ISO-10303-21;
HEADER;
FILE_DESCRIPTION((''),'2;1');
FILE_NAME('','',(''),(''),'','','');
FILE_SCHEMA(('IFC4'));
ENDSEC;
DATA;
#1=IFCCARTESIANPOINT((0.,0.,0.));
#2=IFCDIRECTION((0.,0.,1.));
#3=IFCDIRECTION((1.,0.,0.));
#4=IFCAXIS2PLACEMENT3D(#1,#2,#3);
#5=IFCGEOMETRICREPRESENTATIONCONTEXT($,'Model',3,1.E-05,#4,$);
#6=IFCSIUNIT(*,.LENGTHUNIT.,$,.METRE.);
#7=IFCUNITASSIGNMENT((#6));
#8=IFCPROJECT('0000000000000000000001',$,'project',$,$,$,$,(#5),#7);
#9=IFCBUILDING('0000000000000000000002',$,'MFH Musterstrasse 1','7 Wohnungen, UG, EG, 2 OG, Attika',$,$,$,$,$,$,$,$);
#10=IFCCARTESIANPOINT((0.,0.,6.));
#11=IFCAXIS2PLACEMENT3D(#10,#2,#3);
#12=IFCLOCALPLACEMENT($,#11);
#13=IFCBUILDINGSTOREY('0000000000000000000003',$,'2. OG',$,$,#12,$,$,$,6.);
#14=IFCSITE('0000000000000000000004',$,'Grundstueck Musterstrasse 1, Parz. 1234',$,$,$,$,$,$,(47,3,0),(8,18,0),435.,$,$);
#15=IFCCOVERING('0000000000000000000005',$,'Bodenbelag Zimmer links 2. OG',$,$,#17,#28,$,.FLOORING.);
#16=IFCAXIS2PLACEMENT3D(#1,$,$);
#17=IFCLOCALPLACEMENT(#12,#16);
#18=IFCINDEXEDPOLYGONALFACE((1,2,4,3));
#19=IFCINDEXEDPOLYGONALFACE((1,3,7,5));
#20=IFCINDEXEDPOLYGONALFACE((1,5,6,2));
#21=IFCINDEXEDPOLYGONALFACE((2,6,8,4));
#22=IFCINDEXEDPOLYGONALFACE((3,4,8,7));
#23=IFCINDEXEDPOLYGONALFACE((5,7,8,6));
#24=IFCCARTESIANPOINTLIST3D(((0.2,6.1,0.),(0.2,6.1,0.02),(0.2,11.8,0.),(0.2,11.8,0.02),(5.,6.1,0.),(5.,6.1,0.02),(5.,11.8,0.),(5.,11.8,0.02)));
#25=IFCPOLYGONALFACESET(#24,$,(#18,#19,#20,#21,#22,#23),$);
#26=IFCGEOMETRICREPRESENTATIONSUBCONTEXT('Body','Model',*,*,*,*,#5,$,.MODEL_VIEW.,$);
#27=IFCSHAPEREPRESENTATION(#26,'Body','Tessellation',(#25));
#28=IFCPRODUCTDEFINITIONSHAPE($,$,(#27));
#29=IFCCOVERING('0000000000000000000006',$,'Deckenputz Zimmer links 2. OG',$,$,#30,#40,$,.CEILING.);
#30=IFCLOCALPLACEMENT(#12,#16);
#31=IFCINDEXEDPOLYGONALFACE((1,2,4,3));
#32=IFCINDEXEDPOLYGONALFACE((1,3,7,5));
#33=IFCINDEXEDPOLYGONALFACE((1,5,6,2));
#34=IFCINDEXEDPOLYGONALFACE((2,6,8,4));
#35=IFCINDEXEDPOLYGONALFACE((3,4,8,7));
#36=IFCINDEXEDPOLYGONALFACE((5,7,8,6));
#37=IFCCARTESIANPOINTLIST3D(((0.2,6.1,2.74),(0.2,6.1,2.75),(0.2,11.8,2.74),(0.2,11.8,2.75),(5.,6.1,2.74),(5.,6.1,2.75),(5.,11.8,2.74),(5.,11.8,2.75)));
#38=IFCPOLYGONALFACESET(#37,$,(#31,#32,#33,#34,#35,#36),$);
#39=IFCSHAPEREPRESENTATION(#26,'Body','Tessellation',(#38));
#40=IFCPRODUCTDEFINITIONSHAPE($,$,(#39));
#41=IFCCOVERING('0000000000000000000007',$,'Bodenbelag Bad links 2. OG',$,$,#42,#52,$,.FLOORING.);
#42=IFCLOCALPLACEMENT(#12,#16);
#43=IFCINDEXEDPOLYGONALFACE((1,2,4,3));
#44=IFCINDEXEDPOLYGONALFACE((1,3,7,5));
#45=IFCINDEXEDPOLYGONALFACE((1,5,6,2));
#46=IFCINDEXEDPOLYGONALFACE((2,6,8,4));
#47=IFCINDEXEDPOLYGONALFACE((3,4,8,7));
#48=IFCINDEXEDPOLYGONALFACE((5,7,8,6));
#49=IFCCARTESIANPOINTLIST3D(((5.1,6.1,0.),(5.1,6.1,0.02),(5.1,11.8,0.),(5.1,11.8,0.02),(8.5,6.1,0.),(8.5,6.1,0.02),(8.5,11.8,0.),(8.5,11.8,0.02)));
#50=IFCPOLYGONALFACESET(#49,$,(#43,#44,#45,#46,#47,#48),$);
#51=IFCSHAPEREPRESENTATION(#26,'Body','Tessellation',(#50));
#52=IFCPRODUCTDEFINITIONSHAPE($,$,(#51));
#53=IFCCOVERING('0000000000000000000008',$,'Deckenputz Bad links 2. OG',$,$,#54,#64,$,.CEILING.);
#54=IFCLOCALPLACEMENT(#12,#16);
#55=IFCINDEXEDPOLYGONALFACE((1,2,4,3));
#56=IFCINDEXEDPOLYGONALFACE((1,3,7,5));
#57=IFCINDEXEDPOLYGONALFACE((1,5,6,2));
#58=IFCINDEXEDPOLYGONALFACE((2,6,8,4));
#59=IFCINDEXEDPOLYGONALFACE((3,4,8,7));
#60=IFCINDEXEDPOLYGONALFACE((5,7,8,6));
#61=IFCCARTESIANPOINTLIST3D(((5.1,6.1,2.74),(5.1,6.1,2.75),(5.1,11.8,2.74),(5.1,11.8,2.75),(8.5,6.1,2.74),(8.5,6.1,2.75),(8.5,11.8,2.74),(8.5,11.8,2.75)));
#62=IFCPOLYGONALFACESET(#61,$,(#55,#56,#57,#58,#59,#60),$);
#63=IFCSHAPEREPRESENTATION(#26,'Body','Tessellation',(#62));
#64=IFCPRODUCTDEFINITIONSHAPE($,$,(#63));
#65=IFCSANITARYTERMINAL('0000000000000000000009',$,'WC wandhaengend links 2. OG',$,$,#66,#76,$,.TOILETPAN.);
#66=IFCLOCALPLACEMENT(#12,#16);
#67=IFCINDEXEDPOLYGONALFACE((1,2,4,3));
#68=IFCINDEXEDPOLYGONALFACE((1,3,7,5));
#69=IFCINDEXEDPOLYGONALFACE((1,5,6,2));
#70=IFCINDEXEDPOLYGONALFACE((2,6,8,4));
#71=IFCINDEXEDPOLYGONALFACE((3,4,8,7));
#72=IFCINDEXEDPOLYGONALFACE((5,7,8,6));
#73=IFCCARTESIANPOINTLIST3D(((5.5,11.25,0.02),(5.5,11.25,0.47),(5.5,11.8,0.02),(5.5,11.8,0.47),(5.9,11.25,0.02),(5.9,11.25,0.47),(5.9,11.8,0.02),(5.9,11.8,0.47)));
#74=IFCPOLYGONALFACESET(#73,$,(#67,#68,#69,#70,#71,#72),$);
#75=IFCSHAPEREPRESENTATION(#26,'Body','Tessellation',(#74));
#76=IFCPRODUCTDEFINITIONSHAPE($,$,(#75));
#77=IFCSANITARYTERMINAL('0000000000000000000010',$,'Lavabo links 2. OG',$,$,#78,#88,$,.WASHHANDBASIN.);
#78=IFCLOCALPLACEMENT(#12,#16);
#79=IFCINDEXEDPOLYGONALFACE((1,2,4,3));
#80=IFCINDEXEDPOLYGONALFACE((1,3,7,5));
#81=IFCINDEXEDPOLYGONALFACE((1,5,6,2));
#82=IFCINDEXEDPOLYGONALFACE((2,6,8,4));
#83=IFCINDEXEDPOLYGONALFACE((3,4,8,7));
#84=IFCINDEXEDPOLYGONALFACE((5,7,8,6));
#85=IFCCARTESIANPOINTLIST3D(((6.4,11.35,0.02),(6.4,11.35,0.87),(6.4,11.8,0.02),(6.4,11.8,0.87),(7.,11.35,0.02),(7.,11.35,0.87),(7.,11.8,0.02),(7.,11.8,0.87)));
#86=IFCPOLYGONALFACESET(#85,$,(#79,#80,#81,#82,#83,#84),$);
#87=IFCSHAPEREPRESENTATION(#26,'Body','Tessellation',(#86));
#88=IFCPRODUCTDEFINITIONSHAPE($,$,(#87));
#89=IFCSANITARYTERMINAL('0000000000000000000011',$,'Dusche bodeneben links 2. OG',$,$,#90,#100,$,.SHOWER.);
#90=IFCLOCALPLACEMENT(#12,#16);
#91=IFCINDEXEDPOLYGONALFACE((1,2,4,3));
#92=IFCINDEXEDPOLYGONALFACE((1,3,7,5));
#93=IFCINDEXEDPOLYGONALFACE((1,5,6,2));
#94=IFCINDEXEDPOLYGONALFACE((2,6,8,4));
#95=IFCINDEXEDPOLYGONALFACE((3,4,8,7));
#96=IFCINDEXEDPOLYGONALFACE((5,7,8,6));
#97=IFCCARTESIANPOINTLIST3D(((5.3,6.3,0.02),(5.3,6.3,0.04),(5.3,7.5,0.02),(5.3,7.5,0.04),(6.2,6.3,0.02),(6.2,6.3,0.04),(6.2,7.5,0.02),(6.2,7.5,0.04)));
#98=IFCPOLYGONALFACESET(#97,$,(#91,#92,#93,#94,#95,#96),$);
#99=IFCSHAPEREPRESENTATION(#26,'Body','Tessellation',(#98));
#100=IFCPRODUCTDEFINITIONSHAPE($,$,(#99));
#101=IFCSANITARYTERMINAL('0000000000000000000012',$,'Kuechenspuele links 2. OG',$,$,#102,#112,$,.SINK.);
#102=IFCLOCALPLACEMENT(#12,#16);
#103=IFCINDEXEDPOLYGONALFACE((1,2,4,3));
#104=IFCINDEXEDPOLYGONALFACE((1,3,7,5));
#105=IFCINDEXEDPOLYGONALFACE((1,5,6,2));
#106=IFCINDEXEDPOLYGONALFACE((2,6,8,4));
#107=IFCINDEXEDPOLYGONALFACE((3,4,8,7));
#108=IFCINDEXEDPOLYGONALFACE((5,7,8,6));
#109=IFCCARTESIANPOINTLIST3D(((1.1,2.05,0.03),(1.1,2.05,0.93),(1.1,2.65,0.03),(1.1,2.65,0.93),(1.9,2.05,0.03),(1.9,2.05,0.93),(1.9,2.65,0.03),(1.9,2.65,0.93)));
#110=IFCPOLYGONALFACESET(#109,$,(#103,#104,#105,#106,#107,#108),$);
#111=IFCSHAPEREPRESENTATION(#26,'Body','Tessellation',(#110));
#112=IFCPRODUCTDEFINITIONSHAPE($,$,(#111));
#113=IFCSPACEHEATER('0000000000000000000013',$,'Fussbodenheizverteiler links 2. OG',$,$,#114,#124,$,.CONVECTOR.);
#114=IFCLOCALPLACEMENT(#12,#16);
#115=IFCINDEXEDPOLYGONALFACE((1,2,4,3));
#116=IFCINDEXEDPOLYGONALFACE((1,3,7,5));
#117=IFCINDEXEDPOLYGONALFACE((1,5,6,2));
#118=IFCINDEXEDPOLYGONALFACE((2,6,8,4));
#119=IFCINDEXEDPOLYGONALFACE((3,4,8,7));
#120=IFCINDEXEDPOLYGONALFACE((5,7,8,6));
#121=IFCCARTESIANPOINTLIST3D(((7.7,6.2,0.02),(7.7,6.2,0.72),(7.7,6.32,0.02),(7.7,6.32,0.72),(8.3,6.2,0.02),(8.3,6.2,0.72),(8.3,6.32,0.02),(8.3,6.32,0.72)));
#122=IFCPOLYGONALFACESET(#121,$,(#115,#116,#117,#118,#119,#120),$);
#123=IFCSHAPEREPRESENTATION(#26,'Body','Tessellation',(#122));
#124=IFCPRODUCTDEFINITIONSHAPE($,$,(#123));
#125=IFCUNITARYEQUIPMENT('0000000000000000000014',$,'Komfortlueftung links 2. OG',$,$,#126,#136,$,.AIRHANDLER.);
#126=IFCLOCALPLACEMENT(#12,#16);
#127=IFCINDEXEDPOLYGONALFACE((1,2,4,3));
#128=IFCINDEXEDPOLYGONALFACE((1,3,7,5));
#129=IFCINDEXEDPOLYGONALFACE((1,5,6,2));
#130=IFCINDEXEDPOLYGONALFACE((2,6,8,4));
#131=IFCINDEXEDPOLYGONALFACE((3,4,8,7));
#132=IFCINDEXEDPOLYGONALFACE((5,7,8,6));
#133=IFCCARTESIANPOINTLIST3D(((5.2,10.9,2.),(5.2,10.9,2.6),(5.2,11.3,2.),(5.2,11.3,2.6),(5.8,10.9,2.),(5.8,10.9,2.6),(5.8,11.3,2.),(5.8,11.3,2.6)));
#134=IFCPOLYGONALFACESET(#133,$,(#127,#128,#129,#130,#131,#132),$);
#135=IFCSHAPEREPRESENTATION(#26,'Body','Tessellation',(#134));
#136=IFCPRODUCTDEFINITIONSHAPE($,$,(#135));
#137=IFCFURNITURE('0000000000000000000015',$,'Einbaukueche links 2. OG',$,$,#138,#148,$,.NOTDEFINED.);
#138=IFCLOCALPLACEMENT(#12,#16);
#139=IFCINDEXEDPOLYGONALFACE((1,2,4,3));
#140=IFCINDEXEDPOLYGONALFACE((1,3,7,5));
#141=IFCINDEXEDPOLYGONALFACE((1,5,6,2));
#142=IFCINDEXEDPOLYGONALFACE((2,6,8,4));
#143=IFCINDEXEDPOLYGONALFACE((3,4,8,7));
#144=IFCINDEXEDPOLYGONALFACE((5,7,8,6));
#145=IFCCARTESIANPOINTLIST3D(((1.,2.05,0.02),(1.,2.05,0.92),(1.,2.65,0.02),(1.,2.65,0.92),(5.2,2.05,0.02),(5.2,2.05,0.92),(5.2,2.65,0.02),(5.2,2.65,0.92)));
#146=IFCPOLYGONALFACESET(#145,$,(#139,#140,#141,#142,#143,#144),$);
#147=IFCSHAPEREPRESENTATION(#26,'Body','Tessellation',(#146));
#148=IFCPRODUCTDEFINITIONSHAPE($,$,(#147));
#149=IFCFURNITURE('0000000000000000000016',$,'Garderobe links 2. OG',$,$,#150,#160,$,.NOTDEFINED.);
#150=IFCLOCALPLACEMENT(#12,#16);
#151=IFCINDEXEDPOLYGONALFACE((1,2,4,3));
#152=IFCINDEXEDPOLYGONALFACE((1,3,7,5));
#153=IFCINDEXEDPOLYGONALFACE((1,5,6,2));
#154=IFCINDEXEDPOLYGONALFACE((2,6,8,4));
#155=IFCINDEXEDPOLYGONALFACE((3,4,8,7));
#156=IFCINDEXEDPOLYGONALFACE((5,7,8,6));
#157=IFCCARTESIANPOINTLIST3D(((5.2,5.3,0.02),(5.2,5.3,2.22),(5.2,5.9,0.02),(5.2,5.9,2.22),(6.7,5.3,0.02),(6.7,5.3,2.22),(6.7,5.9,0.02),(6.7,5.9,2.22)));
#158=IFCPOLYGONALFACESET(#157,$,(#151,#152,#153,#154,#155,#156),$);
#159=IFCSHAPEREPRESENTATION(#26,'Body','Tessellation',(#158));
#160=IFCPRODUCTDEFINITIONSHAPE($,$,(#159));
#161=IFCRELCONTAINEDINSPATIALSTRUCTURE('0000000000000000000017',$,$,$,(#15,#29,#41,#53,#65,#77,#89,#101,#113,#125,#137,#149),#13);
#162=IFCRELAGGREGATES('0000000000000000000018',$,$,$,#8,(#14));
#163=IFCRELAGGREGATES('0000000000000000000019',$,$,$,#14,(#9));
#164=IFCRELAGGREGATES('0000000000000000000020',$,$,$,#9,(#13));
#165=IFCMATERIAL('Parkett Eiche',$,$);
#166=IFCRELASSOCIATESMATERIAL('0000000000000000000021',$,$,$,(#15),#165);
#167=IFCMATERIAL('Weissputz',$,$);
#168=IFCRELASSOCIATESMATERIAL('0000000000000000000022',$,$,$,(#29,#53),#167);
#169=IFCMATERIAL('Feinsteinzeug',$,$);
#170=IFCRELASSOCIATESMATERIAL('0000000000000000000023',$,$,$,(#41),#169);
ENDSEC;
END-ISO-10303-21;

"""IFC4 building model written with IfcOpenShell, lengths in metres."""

from ifc_helpers import new_model, si_unit, frame, frame_2d, origin_with_axes, place, context, subcontext, project, spatial, rectangle, extrude, material, element, save


model = new_model("IFC4")

# Units and contexts
model_context = context("Model", 3, precision=1e-05, world=origin_with_axes())
body_context = subcontext(model_context, "Body", "Model", "MODEL_VIEW")
ifc_project = project(units=[si_unit("LENGTHUNIT", "METRE")], contexts=[model_context])

# Site, building, storey
site = spatial("IfcSite", under=ifc_project, Name="Grundstueck Musterstrasse 1, Parz. 1234", RefLatitude=(47, 3, 0), RefLongitude=(8, 18, 0), RefElevation=435.0)
building = spatial("IfcBuilding", under=site, Name="MFH Musterstrasse 1", Description="7 Wohnungen, UG, EG, 2 OG, Attika")
storey_placement = place(None, frame((0.0, 0.0, 6.0), z_axis=(0.0, 0.0, 1.0), x_axis=(1.0, 0.0, 0.0)))
storey = spatial("IfcBuildingStorey", under=building, at=storey_placement, Name="2. OG", Elevation=6.0)

# Coverings
ifc_material_1 = material(Name="Parkett Eiche")
covering_1_placement = place(storey_placement, frame((0.2, 6.1, 0.0), z_axis=(0.0, 0.0, 1.0), x_axis=(1.0, 0.0, 0.0)))
element("IfcCovering", 1, at=covering_1_placement, inside=storey, material=ifc_material_1, Name="Bodenbelag Zimmer links 2. OG", PredefinedType="FLOORING", context=body_context, shape_type="SweptSolid", body=[
    extrude(rectangle(XDim=4.8, YDim=5.7, at=frame_2d((2.4, 2.85))), origin_with_axes(), (0.0, 0.0, 1.0), 0.02),
])
ifc_material_2 = material(Name="Weissputz")
covering_2_placement = place(storey_placement, frame((0.2, 6.1, 2.74), z_axis=(0.0, 0.0, 1.0), x_axis=(1.0, 0.0, 0.0)))
element("IfcCovering", 2, at=covering_2_placement, inside=storey, material=ifc_material_2, Name="Deckenputz Zimmer links 2. OG", PredefinedType="CEILING", context=body_context, shape_type="SweptSolid", body=[
    extrude(rectangle(XDim=4.8, YDim=5.7, at=frame_2d((2.4, 2.85))), origin_with_axes(), (0.0, 0.0, 1.0), 0.01),
])
ifc_material_3 = material(Name="Feinsteinzeug")
covering_3_placement = place(storey_placement, frame((5.1, 6.1, 0.0), z_axis=(0.0, 0.0, 1.0), x_axis=(1.0, 0.0, 0.0)))
element("IfcCovering", 3, at=covering_3_placement, inside=storey, material=ifc_material_3, Name="Bodenbelag Bad links 2. OG", PredefinedType="FLOORING", context=body_context, shape_type="SweptSolid", body=[
    extrude(rectangle(XDim=3.4, YDim=5.7, at=frame_2d((1.7, 2.85))), origin_with_axes(), (0.0, 0.0, 1.0), 0.02),
])
covering_4_placement = place(storey_placement, frame((5.1, 6.1, 2.74), z_axis=(0.0, 0.0, 1.0), x_axis=(1.0, 0.0, 0.0)))
element("IfcCovering", 4, at=covering_4_placement, inside=storey, material=ifc_material_2, Name="Deckenputz Bad links 2. OG", PredefinedType="CEILING", context=body_context, shape_type="SweptSolid", body=[
    extrude(rectangle(XDim=3.4, YDim=5.7, at=frame_2d((1.7, 2.85))), origin_with_axes(), (0.0, 0.0, 1.0), 0.01),
])

# Sanitary terminals
sanitary_terminal_1_placement = place(storey_placement, frame((5.5, 11.25, 0.02), z_axis=(0.0, 0.0, 1.0), x_axis=(1.0, 0.0, 0.0)))
element("IfcSanitaryTerminal", 5, at=sanitary_terminal_1_placement, inside=storey, Name="WC wandhaengend links 2. OG", PredefinedType="TOILETPAN", context=body_context, shape_type="SweptSolid", body=[
    extrude(rectangle(XDim=0.4, YDim=0.55, at=frame_2d((0.2, 0.275))), origin_with_axes(), (0.0, 0.0, 1.0), 0.45),
])
sanitary_terminal_2_placement = place(storey_placement, frame((6.4, 11.35, 0.02), z_axis=(0.0, 0.0, 1.0), x_axis=(1.0, 0.0, 0.0)))
element("IfcSanitaryTerminal", 6, at=sanitary_terminal_2_placement, inside=storey, Name="Lavabo links 2. OG", PredefinedType="WASHHANDBASIN", context=body_context, shape_type="SweptSolid", body=[
    extrude(rectangle(XDim=0.6, YDim=0.45, at=frame_2d((0.3, 0.225))), origin_with_axes(), (0.0, 0.0, 1.0), 0.85),
])
sanitary_terminal_3_placement = place(storey_placement, frame((5.3, 6.3, 0.02), z_axis=(0.0, 0.0, 1.0), x_axis=(1.0, 0.0, 0.0)))
element("IfcSanitaryTerminal", 7, at=sanitary_terminal_3_placement, inside=storey, Name="Dusche bodeneben links 2. OG", PredefinedType="SHOWER", context=body_context, shape_type="SweptSolid", body=[
    extrude(rectangle(XDim=0.9, YDim=1.2, at=frame_2d((0.45, 0.6))), origin_with_axes(), (0.0, 0.0, 1.0), 0.02),
])
sanitary_terminal_4_placement = place(storey_placement, frame((1.1, 2.05, 0.03), z_axis=(0.0, 0.0, 1.0), x_axis=(1.0, 0.0, 0.0)))
element("IfcSanitaryTerminal", 8, at=sanitary_terminal_4_placement, inside=storey, Name="Kuechenspuele links 2. OG", PredefinedType="SINK", context=body_context, shape_type="SweptSolid", body=[
    extrude(rectangle(XDim=0.8, YDim=0.6, at=frame_2d((0.4, 0.3))), origin_with_axes(), (0.0, 0.0, 1.0), 0.9),
])

# Space heater
space_heater_placement = place(storey_placement, frame((7.7, 6.2, 0.02), z_axis=(0.0, 0.0, 1.0), x_axis=(1.0, 0.0, 0.0)))
element("IfcSpaceHeater", 9, at=space_heater_placement, inside=storey, Name="Fussbodenheizverteiler links 2. OG", PredefinedType="CONVECTOR", context=body_context, shape_type="SweptSolid", body=[
    extrude(rectangle(XDim=0.6, YDim=0.12, at=frame_2d((0.3, 0.06))), origin_with_axes(), (0.0, 0.0, 1.0), 0.7),
])

# Unitary equipment
unitary_equipment_placement = place(storey_placement, frame((5.2, 10.9, 2.0), z_axis=(0.0, 0.0, 1.0), x_axis=(1.0, 0.0, 0.0)))
element("IfcUnitaryEquipment", 10, at=unitary_equipment_placement, inside=storey, Name="Komfortlueftung links 2. OG", PredefinedType="AIRHANDLER", context=body_context, shape_type="SweptSolid", body=[
    extrude(rectangle(XDim=0.6, YDim=0.4, at=frame_2d((0.3, 0.2))), origin_with_axes(), (0.0, 0.0, 1.0), 0.6),
])

# Furniture
furniture_1_placement = place(storey_placement, frame((1.0, 2.05, 0.02), z_axis=(0.0, 0.0, 1.0), x_axis=(1.0, 0.0, 0.0)))
element("IfcFurniture", 11, at=furniture_1_placement, inside=storey, Name="Einbaukueche links 2. OG", PredefinedType="NOTDEFINED", context=body_context, shape_type="SweptSolid", body=[
    extrude(rectangle(XDim=4.2, YDim=0.6, at=frame_2d((2.1, 0.3))), origin_with_axes(), (0.0, 0.0, 1.0), 0.9),
])
furniture_2_placement = place(storey_placement, frame((5.2, 5.3, 0.02), z_axis=(0.0, 0.0, 1.0), x_axis=(1.0, 0.0, 0.0)))
element("IfcFurniture", 12, at=furniture_2_placement, inside=storey, Name="Garderobe links 2. OG", PredefinedType="NOTDEFINED", context=body_context, shape_type="SweptSolid", body=[
    extrude(rectangle(XDim=1.5, YDim=0.6, at=frame_2d((0.75, 0.3))), origin_with_axes(), (0.0, 0.0, 1.0), 2.2),
])

save(model, "model.ifc")
